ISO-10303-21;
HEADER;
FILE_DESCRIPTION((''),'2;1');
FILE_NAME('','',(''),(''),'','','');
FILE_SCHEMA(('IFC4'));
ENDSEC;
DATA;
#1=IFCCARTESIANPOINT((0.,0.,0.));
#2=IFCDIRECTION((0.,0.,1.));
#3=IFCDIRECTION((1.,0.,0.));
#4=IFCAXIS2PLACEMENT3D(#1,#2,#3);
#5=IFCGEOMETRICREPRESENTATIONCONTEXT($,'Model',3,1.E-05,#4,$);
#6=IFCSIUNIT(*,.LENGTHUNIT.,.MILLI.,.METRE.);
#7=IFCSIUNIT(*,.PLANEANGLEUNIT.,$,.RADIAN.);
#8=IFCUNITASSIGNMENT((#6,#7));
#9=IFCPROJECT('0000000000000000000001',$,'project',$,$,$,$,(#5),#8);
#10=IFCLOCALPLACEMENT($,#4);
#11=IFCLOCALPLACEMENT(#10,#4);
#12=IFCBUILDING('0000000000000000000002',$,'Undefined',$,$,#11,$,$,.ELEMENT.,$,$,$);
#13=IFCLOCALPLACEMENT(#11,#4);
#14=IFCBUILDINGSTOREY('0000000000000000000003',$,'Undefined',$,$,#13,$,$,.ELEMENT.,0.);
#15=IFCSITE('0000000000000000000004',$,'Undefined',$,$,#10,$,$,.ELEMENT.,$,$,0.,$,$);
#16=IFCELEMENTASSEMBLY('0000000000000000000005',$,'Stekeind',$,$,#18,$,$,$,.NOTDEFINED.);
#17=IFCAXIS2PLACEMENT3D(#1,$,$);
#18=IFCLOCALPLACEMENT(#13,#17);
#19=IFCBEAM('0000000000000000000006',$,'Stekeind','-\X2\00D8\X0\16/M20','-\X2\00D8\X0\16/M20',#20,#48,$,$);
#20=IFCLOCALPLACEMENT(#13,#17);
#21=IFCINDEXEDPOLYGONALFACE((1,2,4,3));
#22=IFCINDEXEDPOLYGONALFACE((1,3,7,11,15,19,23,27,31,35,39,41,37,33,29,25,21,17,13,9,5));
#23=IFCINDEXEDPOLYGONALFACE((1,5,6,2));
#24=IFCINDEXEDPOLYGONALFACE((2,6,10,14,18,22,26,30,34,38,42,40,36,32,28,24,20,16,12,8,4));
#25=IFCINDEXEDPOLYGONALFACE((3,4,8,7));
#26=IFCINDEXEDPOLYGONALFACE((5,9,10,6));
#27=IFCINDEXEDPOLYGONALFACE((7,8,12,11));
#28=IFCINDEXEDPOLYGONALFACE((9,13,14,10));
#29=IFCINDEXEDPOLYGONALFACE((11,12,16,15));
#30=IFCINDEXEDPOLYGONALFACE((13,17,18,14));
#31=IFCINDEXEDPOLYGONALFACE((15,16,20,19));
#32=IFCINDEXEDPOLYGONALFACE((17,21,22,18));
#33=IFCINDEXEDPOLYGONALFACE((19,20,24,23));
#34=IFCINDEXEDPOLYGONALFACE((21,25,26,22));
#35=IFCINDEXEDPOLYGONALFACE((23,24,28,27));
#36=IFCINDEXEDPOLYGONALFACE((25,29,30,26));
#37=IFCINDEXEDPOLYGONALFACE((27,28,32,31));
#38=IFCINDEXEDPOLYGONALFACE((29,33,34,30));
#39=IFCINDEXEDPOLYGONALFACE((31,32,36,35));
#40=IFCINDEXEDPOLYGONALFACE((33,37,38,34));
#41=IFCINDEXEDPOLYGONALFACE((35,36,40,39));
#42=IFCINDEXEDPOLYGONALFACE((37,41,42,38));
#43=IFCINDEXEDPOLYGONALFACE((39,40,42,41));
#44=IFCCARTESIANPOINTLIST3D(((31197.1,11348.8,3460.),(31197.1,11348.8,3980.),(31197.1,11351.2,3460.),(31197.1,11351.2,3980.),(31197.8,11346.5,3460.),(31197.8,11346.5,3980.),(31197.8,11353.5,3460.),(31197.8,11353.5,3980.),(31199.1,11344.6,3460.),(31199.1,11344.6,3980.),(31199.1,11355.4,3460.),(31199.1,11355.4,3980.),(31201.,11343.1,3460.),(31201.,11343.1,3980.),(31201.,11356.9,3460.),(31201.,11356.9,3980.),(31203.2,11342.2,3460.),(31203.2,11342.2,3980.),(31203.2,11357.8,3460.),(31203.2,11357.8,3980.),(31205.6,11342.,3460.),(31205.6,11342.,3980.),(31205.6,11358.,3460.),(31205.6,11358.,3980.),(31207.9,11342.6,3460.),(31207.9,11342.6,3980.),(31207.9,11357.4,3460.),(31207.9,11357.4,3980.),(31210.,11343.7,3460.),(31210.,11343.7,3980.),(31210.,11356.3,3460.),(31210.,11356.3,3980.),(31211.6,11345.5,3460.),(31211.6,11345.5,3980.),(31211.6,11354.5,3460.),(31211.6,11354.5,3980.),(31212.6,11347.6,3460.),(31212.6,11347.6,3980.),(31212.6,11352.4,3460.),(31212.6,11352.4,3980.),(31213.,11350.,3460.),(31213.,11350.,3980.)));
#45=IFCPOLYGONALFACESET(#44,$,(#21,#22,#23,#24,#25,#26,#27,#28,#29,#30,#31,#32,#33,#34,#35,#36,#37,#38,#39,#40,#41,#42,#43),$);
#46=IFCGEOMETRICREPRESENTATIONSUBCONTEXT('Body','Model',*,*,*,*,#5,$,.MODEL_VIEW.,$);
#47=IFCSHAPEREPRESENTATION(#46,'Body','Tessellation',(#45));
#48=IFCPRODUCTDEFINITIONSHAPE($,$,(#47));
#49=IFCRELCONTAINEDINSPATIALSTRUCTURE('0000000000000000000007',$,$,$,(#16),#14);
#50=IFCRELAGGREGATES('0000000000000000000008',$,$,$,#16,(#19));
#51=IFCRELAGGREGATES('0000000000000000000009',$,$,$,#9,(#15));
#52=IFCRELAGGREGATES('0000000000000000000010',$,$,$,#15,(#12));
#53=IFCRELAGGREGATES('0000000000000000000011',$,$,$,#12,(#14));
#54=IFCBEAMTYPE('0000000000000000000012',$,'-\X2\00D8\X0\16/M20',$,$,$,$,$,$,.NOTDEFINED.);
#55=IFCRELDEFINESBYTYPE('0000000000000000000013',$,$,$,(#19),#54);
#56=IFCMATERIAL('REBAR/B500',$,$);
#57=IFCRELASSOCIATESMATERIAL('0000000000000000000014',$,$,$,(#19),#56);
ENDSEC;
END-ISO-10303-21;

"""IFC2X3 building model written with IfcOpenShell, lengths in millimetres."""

from ifc_helpers import new_model, si_unit, frame, origin_with_axes, origin_2d_with_axis, place, context, subcontext, project, spatial, circle, extrude, material, type_object, element, aggregate, save


model = new_model("IFC2X3")

# Units and contexts
model_context = context("Model", 3, precision=1e-05, world=origin_with_axes())
body_context = subcontext(model_context, "Body", "Model", "MODEL_VIEW")
ifc_project = project(units=[si_unit("LENGTHUNIT", "METRE", prefix="MILLI"), si_unit("PLANEANGLEUNIT", "RADIAN")], contexts=[model_context])

# Site, building, storey
site_placement = place(None, origin_with_axes())
site = spatial("IfcSite", under=ifc_project, at=site_placement, Name="Undefined", CompositionType="ELEMENT", RefElevation=0.0)
building_placement = place(site_placement, origin_with_axes())
building = spatial("IfcBuilding", under=site, at=building_placement, Name="Undefined", CompositionType="ELEMENT")
storey_placement = place(building_placement, origin_with_axes())
storey = spatial("IfcBuildingStorey", under=building, at=storey_placement, Name="Undefined", CompositionType="ELEMENT", Elevation=0.0)

# Element assembly, beam
ifc_material_1 = material(Name="REBAR/B500")
beam_type_1 = type_object("IfcBeamType", Name="-Ø16/M20", PredefinedType="NOTDEFINED")
assembly_1_placement = place(storey_placement, origin_with_axes())
assembly_1 = element("IfcElementAssembly", 1, at=assembly_1_placement, inside=storey, Name="Stekeind", PredefinedType="NOTDEFINED")
beam_1_placement = place(assembly_1_placement, frame((31205.0, 11350.0, 3980.0), z_axis=(0.0, 1.0, 0.0), x_axis=(0.0, 0.0, -1.0)))
beam_1 = element("IfcBeam", 2, at=beam_1_placement, type_object=beam_type_1, material=ifc_material_1, Name="Stekeind", Description="-Ø16/M20", ObjectType="-Ø16/M20", context=body_context, shape_type="SweptSolid", body=[
    extrude(circle(Radius=8.0, at=origin_2d_with_axis()), frame((520.0, 0.0, 0.0), z_axis=(-1.0, 0.0, 0.0), x_axis=(0.0, -1.0, 0.0)), (0.0, 0.0, 1.0), 520.0),
])
aggregate(assembly_1, [beam_1])

save(model, "model.ifc")
